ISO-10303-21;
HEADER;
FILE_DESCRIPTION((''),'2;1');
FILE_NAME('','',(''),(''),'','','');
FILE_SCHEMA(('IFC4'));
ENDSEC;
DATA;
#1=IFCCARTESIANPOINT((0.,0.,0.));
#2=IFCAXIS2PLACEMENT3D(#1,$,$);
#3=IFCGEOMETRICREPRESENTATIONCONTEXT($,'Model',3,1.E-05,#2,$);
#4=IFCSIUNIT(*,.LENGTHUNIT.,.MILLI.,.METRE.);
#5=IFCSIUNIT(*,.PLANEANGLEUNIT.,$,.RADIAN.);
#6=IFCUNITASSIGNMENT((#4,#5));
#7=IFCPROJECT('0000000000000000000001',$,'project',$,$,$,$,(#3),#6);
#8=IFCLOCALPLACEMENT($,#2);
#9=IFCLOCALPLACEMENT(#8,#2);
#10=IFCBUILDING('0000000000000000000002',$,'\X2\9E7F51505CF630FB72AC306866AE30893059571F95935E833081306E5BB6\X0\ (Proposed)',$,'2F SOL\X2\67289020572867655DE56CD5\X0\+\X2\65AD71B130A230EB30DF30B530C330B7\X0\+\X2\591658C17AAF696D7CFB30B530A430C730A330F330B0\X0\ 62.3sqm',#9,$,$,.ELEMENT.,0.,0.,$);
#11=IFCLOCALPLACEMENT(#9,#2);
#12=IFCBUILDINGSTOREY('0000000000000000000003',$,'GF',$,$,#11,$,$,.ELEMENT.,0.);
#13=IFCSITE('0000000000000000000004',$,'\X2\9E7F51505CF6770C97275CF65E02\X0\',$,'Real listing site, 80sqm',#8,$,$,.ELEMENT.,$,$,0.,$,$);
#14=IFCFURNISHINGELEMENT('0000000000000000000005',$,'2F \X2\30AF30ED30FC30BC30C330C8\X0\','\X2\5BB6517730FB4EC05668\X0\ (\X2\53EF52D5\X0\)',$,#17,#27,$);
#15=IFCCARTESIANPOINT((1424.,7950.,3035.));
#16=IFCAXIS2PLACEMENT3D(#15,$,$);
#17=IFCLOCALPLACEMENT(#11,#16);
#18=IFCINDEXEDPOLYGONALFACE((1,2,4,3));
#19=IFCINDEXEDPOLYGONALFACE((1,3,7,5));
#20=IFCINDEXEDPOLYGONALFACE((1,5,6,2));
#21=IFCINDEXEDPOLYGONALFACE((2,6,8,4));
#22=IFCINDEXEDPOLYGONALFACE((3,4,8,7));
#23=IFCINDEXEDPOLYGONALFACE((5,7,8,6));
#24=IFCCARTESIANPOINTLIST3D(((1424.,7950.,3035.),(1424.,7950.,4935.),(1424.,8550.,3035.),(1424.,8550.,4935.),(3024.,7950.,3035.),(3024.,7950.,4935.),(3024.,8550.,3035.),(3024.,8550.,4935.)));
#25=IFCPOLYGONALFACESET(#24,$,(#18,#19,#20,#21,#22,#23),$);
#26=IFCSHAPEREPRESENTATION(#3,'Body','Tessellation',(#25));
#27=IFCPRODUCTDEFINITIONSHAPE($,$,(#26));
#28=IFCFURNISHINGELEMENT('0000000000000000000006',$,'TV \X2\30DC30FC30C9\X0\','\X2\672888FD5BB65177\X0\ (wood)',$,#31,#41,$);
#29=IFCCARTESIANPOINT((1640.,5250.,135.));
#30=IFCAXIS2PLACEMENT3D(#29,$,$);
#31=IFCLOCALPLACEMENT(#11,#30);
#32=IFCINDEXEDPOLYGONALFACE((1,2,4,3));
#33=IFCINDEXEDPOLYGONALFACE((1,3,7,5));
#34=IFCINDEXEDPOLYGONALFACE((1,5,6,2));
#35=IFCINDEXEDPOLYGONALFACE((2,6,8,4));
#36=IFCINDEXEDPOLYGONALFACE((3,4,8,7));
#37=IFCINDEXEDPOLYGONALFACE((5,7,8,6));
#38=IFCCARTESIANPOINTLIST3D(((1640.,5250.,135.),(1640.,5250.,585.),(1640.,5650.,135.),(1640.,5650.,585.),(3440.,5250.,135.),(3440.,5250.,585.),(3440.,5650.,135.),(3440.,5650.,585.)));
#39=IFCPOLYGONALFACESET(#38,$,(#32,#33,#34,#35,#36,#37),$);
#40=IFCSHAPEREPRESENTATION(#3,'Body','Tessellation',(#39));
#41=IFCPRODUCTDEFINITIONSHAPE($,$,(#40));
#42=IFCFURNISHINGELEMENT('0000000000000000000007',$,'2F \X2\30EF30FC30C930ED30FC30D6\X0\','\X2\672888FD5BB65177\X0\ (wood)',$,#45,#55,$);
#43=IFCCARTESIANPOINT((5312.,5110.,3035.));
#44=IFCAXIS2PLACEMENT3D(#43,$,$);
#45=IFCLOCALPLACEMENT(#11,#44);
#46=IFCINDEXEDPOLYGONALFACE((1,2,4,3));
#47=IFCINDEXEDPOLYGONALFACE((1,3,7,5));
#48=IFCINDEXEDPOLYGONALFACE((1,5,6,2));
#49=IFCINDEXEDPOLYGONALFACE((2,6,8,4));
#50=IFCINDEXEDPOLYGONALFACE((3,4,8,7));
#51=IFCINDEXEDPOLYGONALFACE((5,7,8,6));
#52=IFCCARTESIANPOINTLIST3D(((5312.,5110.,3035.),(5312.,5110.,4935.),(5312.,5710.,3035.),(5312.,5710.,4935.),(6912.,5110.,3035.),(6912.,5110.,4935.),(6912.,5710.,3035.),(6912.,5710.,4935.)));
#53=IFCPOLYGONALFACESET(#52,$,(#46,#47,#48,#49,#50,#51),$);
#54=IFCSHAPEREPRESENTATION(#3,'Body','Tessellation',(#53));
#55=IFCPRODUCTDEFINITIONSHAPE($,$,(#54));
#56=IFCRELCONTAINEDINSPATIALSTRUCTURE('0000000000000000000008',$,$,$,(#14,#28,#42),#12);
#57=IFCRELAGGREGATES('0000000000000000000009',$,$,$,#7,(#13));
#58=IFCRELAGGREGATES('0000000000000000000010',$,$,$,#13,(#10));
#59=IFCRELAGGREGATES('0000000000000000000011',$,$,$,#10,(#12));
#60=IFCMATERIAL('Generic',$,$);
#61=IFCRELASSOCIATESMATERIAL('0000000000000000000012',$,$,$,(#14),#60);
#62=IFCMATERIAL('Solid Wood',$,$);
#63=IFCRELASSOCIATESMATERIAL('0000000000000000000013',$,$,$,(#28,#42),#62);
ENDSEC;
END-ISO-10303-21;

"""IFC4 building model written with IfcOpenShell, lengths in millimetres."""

from ifc_helpers import new_model, si_unit, frame, frame_2d, origin, place, context, project, spatial, rectangle, extrude, material, element, save


model = new_model("IFC4")

# Units and contexts
model_context = context("Model", 3, precision=1e-05, world=origin())
ifc_project = project(units=[si_unit("LENGTHUNIT", "METRE", prefix="MILLI"), si_unit("PLANEANGLEUNIT", "RADIAN")], contexts=[model_context])

# Site, building, storey
site_placement = place(None, origin())
site = spatial("IfcSite", under=ifc_project, at=site_placement, Name="鹿児島県霧島市", ObjectType="Real listing site, 80sqm", CompositionType="ELEMENT", RefElevation=0.0)
building_placement = place(site_placement, origin())
building = spatial("IfcBuilding", under=site, at=building_placement, Name="鹿児島・犬と暮らす土間広めの家 (Proposed)", ObjectType="2F SOL木造在来工法+断熱アルミサッシ+外壁窯業系サイディング 62.3sqm", CompositionType="ELEMENT", ElevationOfRefHeight=0.0, ElevationOfTerrain=0.0)
storey_placement = place(building_placement, origin())
storey = spatial("IfcBuildingStorey", under=building, at=storey_placement, Name="GF", CompositionType="ELEMENT", Elevation=0.0)

# Shared definitions
ifc_material_1 = material(Name="Solid Wood")

# Shared definitions
ifc_material_2 = material(Name="Generic")

# Furnishing elements
furnishing_1_placement = place(storey_placement, frame((1424.0, 7950.0, 3035.0)))
element("IfcFurnishingElement", 1, at=furnishing_1_placement, inside=storey, material=ifc_material_2, Name="2F クローゼット", Description="家具・什器 (可動)", context=model_context, shape_type="SweptSolid", body=[
    extrude(rectangle(XDim=1600.0, YDim=600.0, at=frame_2d((800.0, 300.0))), frame((1424.0, 7950.0, 3035.0)), (0.0, 0.0, 1.0), 1900.0),
])
furnishing_2_placement = place(storey_placement, frame((1640.0, 5250.0, 135.0)))
element("IfcFurnishingElement", 2, at=furnishing_2_placement, inside=storey, material=ifc_material_1, Name="TV ボード", Description="木製家具 (wood)", context=model_context, shape_type="SweptSolid", body=[
    extrude(rectangle(XDim=1800.0, YDim=400.0, at=frame_2d((900.0, 200.0))), frame((1640.0, 5250.0, 135.0)), (0.0, 0.0, 1.0), 450.0),
])
furnishing_3_placement = place(storey_placement, frame((5312.0, 5110.0, 3035.0)))
element("IfcFurnishingElement", 3, at=furnishing_3_placement, inside=storey, material=ifc_material_1, Name="2F ワードローブ", Description="木製家具 (wood)", context=model_context, shape_type="SweptSolid", body=[
    extrude(rectangle(XDim=1600.0, YDim=600.0, at=frame_2d((800.0, 300.0))), frame((5312.0, 5110.0, 3035.0)), (0.0, 0.0, 1.0), 1900.0),
])

save(model, "model.ifc")
